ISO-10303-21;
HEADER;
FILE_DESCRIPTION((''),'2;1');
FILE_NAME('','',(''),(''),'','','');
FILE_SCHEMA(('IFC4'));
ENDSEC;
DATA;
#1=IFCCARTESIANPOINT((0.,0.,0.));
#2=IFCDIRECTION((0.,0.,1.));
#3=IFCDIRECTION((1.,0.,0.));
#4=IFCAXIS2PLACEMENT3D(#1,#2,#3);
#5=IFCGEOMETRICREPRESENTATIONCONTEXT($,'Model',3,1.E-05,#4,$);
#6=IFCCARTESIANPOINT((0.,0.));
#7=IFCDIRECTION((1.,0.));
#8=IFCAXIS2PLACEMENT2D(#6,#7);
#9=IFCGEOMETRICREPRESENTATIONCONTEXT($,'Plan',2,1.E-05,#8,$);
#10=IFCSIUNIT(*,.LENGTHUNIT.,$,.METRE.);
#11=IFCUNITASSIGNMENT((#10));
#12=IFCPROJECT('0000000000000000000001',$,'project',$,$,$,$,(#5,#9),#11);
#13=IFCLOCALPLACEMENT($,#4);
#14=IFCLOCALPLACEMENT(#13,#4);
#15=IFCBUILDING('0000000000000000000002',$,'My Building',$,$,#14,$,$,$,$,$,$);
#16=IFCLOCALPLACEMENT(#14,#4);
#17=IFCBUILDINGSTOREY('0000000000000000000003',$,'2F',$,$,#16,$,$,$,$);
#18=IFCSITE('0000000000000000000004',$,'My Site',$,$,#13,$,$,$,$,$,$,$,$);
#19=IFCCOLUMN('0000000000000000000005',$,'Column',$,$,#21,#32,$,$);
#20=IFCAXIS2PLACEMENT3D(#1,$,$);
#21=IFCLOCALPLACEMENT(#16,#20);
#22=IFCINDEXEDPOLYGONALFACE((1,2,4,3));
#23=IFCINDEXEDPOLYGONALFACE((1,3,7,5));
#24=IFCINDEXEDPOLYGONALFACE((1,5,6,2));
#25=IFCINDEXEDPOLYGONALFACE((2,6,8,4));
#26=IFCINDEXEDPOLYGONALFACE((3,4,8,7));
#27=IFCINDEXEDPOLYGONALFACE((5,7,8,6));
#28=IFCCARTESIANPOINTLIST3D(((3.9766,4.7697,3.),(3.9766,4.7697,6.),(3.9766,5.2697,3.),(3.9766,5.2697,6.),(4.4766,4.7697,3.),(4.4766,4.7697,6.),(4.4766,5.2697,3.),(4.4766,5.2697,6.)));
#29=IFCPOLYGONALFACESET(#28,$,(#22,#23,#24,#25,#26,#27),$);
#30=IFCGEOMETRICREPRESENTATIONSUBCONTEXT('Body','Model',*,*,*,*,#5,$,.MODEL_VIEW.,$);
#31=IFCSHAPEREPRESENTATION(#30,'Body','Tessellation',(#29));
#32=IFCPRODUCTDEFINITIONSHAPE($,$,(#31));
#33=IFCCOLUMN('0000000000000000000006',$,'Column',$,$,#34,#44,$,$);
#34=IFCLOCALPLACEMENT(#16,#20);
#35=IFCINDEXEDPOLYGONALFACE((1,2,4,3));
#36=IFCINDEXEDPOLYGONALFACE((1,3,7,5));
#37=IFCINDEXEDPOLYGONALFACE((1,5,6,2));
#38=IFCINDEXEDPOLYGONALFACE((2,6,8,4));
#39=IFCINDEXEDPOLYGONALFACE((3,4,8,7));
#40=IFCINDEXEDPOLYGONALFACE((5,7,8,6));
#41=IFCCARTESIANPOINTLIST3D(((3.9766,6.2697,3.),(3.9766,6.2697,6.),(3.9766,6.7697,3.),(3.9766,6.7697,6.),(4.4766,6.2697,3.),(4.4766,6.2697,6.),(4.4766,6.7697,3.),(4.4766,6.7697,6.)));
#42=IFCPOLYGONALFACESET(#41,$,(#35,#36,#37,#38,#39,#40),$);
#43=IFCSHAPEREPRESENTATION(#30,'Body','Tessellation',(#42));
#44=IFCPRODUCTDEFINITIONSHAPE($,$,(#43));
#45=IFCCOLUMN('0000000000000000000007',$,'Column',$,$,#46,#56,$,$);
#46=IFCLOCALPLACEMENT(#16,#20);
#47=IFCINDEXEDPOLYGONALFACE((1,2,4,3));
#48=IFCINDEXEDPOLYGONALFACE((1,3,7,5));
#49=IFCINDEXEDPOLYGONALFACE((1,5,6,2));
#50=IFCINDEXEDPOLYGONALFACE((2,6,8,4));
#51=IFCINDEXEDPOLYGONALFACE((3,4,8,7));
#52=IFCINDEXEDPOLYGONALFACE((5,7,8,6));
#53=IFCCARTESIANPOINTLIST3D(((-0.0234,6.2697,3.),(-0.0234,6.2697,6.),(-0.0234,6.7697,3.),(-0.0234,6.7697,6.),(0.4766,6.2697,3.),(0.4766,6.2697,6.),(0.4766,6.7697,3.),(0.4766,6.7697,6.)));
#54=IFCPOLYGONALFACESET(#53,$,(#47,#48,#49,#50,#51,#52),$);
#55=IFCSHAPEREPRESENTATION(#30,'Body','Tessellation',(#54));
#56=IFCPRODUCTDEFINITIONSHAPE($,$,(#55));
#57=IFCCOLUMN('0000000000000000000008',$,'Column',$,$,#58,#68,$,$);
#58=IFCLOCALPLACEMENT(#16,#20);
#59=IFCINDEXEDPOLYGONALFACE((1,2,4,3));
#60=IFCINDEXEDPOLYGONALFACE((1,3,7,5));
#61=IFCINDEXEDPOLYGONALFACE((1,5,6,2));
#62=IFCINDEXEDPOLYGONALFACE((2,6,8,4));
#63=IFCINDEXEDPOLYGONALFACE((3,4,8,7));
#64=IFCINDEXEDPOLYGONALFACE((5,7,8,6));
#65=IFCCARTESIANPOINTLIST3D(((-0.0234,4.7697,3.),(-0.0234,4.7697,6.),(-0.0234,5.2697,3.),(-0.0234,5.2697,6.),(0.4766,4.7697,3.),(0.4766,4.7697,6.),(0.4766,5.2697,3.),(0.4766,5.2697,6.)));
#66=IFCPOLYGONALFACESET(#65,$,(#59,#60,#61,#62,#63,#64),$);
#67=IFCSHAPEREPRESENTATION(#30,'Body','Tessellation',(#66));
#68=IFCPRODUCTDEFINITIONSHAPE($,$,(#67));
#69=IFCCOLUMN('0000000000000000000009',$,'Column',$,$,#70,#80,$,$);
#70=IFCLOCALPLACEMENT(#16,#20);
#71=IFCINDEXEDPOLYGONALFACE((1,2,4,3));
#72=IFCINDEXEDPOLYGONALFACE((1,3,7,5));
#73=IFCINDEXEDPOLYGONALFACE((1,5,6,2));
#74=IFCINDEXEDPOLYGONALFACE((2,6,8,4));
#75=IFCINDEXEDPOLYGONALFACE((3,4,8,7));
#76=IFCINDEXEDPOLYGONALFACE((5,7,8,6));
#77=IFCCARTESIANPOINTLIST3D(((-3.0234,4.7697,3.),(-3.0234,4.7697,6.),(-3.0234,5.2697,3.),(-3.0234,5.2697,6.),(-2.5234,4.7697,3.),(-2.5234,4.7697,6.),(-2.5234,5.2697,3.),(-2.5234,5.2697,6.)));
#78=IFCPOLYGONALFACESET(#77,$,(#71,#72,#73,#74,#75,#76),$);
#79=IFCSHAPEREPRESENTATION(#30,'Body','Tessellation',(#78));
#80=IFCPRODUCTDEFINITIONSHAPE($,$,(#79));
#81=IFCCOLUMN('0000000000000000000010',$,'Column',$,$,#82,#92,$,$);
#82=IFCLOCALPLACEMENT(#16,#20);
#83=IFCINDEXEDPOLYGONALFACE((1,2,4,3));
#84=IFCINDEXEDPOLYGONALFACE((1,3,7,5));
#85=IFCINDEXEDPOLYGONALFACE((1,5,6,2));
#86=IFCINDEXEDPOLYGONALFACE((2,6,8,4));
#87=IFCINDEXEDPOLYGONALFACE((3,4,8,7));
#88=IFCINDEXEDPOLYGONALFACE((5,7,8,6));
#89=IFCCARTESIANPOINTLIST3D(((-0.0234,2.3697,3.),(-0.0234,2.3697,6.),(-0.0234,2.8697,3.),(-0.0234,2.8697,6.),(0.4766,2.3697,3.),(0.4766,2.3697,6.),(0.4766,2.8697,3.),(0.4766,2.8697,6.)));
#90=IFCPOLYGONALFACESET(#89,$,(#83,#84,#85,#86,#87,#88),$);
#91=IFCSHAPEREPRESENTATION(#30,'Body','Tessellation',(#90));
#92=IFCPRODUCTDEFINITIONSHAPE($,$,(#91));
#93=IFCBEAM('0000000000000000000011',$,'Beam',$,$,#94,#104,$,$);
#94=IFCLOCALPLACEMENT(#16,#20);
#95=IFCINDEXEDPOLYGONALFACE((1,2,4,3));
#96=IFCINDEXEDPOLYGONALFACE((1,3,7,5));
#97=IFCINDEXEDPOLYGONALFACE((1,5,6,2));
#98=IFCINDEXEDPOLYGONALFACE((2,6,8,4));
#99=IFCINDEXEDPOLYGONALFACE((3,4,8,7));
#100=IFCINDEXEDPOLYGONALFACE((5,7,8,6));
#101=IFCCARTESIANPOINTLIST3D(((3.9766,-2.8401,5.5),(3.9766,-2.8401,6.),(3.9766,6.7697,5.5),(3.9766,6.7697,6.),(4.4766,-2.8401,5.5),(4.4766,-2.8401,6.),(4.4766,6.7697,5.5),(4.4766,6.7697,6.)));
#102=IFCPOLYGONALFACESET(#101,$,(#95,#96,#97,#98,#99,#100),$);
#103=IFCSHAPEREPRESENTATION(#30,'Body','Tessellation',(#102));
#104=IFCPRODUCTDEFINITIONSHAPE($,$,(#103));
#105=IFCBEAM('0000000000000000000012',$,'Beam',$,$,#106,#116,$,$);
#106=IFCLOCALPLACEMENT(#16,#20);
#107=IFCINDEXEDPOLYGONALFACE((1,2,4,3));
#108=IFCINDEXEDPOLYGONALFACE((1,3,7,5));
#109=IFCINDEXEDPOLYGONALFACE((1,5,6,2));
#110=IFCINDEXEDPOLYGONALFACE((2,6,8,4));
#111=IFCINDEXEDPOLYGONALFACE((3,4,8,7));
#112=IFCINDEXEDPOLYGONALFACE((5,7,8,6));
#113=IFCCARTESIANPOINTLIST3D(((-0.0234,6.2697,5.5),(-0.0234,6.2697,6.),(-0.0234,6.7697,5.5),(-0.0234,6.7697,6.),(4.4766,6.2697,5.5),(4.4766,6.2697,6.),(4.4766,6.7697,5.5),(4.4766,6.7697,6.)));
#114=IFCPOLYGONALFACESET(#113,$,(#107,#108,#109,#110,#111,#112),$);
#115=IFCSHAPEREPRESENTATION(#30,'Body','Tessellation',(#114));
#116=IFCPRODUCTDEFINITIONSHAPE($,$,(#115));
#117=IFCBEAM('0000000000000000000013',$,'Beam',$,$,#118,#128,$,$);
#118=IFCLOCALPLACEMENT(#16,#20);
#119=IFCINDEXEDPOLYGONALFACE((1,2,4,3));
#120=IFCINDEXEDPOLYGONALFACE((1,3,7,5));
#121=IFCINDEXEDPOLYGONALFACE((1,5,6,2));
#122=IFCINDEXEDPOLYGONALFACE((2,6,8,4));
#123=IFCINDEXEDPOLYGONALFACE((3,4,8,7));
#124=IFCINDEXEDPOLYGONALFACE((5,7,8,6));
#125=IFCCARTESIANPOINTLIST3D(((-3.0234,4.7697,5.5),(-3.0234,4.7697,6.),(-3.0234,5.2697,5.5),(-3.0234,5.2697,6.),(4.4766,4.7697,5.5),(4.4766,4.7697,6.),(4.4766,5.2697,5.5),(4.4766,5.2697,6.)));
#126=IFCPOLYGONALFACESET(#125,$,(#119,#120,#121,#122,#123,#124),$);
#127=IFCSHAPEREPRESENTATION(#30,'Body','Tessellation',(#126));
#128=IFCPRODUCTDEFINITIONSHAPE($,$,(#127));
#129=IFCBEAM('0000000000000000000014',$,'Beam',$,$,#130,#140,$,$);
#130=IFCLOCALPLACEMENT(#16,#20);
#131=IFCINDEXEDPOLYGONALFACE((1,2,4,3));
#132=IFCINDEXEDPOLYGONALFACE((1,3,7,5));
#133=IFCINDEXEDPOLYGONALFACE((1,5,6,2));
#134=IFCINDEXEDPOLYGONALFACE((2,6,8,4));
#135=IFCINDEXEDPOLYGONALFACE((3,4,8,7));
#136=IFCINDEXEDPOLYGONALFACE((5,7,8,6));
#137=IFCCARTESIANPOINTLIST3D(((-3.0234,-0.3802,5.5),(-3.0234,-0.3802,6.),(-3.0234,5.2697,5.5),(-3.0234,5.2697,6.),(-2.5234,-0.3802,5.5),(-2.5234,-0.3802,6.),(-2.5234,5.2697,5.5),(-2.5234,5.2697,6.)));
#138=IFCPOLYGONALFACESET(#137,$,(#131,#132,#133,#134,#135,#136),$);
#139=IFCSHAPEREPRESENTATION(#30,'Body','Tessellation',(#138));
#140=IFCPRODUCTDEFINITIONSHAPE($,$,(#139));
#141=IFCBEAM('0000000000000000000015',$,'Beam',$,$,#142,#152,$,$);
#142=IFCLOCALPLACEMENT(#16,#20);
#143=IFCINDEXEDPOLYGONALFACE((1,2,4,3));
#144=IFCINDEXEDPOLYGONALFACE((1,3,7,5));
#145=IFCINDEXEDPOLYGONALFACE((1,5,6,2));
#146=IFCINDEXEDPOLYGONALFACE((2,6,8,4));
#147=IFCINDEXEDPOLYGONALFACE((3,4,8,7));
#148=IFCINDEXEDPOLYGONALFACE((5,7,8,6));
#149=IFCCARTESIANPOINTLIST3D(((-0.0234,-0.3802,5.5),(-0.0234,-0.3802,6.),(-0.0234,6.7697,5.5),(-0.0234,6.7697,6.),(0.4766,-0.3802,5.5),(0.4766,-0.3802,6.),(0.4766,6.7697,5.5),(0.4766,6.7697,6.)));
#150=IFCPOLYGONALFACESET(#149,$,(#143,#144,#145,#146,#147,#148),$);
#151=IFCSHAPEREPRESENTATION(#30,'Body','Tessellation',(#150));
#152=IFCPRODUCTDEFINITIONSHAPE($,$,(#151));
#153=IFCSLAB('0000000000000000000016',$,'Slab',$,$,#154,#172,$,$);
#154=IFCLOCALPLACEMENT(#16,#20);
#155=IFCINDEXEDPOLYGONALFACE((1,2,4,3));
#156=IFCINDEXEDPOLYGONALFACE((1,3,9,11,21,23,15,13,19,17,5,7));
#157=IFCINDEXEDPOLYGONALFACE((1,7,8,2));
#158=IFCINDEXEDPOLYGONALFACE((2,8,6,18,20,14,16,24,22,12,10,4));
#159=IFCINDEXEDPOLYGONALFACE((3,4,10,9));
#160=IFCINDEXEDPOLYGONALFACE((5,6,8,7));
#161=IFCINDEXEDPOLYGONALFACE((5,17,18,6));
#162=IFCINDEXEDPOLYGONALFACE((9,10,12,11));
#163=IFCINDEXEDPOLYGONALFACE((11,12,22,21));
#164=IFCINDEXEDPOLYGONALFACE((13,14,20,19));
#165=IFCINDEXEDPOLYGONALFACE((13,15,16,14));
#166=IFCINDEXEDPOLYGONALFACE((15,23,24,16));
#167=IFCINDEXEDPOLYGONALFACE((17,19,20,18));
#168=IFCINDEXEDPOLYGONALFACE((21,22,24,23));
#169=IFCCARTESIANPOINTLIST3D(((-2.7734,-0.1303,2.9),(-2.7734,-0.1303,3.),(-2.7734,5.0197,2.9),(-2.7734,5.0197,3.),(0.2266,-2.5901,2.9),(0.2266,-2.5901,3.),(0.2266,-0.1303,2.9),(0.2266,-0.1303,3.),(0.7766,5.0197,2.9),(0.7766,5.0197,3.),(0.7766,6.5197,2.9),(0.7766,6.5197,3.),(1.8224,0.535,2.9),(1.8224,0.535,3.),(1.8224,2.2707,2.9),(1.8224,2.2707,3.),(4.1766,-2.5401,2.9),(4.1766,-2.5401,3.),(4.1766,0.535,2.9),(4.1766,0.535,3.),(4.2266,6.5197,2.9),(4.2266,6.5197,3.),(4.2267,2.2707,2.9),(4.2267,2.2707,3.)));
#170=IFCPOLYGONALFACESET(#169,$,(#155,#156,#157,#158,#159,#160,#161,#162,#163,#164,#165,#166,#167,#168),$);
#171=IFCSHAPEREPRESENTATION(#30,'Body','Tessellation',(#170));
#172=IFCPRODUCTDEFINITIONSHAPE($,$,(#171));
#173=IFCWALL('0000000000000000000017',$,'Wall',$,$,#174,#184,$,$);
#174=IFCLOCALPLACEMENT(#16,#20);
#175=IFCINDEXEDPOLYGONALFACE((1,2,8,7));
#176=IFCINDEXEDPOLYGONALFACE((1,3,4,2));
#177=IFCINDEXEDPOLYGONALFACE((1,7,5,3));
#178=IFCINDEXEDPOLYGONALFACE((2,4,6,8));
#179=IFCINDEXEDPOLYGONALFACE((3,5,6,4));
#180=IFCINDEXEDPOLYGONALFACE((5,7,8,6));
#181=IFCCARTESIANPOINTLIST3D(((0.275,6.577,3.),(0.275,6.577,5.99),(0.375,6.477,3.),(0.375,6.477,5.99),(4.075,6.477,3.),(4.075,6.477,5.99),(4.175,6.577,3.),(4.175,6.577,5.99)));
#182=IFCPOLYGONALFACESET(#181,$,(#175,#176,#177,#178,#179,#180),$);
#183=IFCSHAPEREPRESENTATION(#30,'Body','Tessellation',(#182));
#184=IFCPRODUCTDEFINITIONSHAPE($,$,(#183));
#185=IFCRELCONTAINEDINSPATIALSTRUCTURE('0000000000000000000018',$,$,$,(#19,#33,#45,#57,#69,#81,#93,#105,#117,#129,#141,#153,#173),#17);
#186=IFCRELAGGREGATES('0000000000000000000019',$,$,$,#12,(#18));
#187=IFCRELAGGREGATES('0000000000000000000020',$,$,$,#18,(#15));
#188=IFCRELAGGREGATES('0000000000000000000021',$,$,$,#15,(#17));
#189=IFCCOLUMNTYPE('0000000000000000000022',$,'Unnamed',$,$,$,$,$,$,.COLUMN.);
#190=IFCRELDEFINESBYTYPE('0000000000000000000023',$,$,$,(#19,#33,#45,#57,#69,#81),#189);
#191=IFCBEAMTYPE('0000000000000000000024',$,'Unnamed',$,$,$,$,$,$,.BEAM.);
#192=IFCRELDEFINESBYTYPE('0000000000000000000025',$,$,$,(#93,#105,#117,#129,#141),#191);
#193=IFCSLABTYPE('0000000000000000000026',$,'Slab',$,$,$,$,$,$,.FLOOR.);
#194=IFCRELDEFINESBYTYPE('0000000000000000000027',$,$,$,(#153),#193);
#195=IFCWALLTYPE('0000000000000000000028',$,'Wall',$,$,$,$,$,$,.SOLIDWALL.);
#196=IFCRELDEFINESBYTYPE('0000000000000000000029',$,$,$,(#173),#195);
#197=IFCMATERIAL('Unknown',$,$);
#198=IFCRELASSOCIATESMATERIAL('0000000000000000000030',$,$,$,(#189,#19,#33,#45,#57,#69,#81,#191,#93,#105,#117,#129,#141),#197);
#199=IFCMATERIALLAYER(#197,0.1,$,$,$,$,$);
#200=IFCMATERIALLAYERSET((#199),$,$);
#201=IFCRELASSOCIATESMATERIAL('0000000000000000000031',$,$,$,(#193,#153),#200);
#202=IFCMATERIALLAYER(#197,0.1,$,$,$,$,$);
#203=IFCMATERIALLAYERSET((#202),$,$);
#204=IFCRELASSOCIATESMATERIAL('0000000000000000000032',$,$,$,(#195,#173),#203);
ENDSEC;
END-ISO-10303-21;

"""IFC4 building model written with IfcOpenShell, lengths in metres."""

from ifc_helpers import new_model, si_unit, frame, origin_with_axes, origin_2d_with_axis, place, context, subcontext, project, spatial, line, indexed_curve, rectangle, outline, extrude, material, layer, layer_set, layer_usage, material_profile, profile_set, profile_usage, type_object, element, save


model = new_model("IFC4")

# Units and contexts
model_context = context("Model", 3, precision=1e-05, world=origin_with_axes())
plan_context = context("Plan", 2, precision=1e-05, world=origin_2d_with_axis())
body_context_1 = subcontext(model_context, "Body", "Model", "MODEL_VIEW")
ifc_project = project(units=[si_unit("LENGTHUNIT", "METRE")], contexts=[model_context, plan_context])

# Site, building, storey
site_placement = place(None, origin_with_axes())
site = spatial("IfcSite", under=ifc_project, at=site_placement, Name="My Site")
building_placement = place(site_placement, origin_with_axes())
building = spatial("IfcBuilding", under=site, at=building_placement, Name="My Building")
storey_placement = place(building_placement, origin_with_axes())
storey = spatial("IfcBuildingStorey", under=building, at=storey_placement, Name="2F")

# Columns
ifc_material = material(Name="Unknown")
ifc_material_profile_1 = material_profile(ifc_material, rectangle(XDim=0.5, YDim=0.5))
ifc_profile_set_1 = profile_set([ifc_material_profile_1])
ifc_profile_usage_1 = profile_usage(ifc_profile_set_1, cardinal=5)
column_type = type_object("IfcColumnType", Name="Unnamed", PredefinedType="COLUMN", material=ifc_profile_set_1)
column_1_placement = place(storey_placement, frame((4.2266, 5.0197, 3.0), z_axis=(0.0, 0.0, 1.0), x_axis=(1.0, 0.0, 0.0)))
element("IfcColumn", 1, at=column_1_placement, inside=storey, type_object=column_type, material=ifc_profile_usage_1, Name="Column", context=body_context_1, shape_type="SweptSolid", body=[
    extrude(rectangle(XDim=0.5, YDim=0.5), origin_with_axes(), (0.0, 0.0, 1.0), 3.0),
])
ifc_profile_usage_2 = profile_usage(ifc_profile_set_1, cardinal=5)
column_2_placement = place(storey_placement, frame((4.2266, 6.5197, 3.0), z_axis=(0.0, 0.0, 1.0), x_axis=(1.0, 0.0, 0.0)))
element("IfcColumn", 2, at=column_2_placement, inside=storey, type_object=column_type, material=ifc_profile_usage_2, Name="Column", context=body_context_1, shape_type="SweptSolid", body=[
    extrude(rectangle(XDim=0.5, YDim=0.5), origin_with_axes(), (0.0, 0.0, 1.0), 3.0),
])
ifc_profile_usage_3 = profile_usage(ifc_profile_set_1, cardinal=5)
column_3_placement = place(storey_placement, frame((0.2266, 6.5197, 3.0), z_axis=(0.0, 0.0, 1.0), x_axis=(1.0, 0.0, 0.0)))
element("IfcColumn", 3, at=column_3_placement, inside=storey, type_object=column_type, material=ifc_profile_usage_3, Name="Column", context=body_context_1, shape_type="SweptSolid", body=[
    extrude(rectangle(XDim=0.5, YDim=0.5), origin_with_axes(), (0.0, 0.0, 1.0), 3.0),
])
ifc_profile_usage_4 = profile_usage(ifc_profile_set_1, cardinal=5)
column_4_placement = place(storey_placement, frame((0.2266, 5.0197, 3.0), z_axis=(0.0, 0.0, 1.0), x_axis=(1.0, 0.0, 0.0)))
element("IfcColumn", 4, at=column_4_placement, inside=storey, type_object=column_type, material=ifc_profile_usage_4, Name="Column", context=body_context_1, shape_type="SweptSolid", body=[
    extrude(rectangle(XDim=0.5, YDim=0.5), origin_with_axes(), (0.0, 0.0, 1.0), 3.0),
])
ifc_profile_usage_5 = profile_usage(ifc_profile_set_1, cardinal=5)
column_5_placement = place(storey_placement, frame((-2.7734, 5.0197, 3.0), z_axis=(0.0, 0.0, 1.0), x_axis=(1.0, 0.0, 0.0)))
element("IfcColumn", 5, at=column_5_placement, inside=storey, type_object=column_type, material=ifc_profile_usage_5, Name="Column", context=body_context_1, shape_type="SweptSolid", body=[
    extrude(rectangle(XDim=0.5, YDim=0.5), origin_with_axes(), (0.0, 0.0, 1.0), 3.0),
])
ifc_profile_usage_6 = profile_usage(ifc_profile_set_1, cardinal=5)
column_6_placement = place(storey_placement, frame((0.2266, 2.6197, 3.0), z_axis=(0.0, 0.0, 1.0), x_axis=(1.0, 0.0, 0.0)))
element("IfcColumn", 6, at=column_6_placement, inside=storey, type_object=column_type, material=ifc_profile_usage_6, Name="Column", context=body_context_1, shape_type="SweptSolid", body=[
    extrude(rectangle(XDim=0.5, YDim=0.5), origin_with_axes(), (0.0, 0.0, 1.0), 3.0),
])

# Beams
ifc_material_profile_2 = material_profile(ifc_material, rectangle(XDim=0.5, YDim=0.5))
ifc_profile_set_2 = profile_set([ifc_material_profile_2])
ifc_profile_usage_7 = profile_usage(ifc_profile_set_2, cardinal=7)
beam_type = type_object("IfcBeamType", Name="Unnamed", PredefinedType="BEAM", material=ifc_profile_set_2)
beam_1_placement = place(storey_placement, frame((4.4766, 6.7697, 6.0), z_axis=(0.0, -1.0, 0.0), x_axis=(1.0, 0.0, 0.0)))
element("IfcBeam", 7, at=beam_1_placement, inside=storey, type_object=beam_type, material=ifc_profile_usage_7, Name="Beam", context=body_context_1, shape_type="SweptSolid", body=[
    extrude(rectangle(XDim=0.5, YDim=0.5), frame((-0.25, -0.25, 0.0), z_axis=(0.0, 0.0, 1.0), x_axis=(1.0, 0.0, 0.0)), (0.0, 0.0, 1.0), 9.6098),
])
ifc_profile_usage_8 = profile_usage(ifc_profile_set_2, cardinal=7)
beam_2_placement = place(storey_placement, frame((4.4766, 6.2697, 6.0), z_axis=(-1.0, -0.000001, 0.000001), x_axis=(0.000001, -1.0, 0.0)))
element("IfcBeam", 8, at=beam_2_placement, inside=storey, type_object=beam_type, material=ifc_profile_usage_8, Name="Beam", context=body_context_1, shape_type="SweptSolid", body=[
    extrude(rectangle(XDim=0.5, YDim=0.5), frame((-0.25, -0.25, 0.0), z_axis=(0.0, 0.0, 1.0), x_axis=(1.0, 0.0, 0.0)), (0.0, 0.0, 1.0), 4.5),
])
ifc_profile_usage_9 = profile_usage(ifc_profile_set_2, cardinal=7)
beam_3_placement = place(storey_placement, frame((4.4766, 4.7697, 6.0), z_axis=(-1.0, 0.0, 0.0), x_axis=(0.0, -1.0, 0.0)))
element("IfcBeam", 9, at=beam_3_placement, inside=storey, type_object=beam_type, material=ifc_profile_usage_9, Name="Beam", context=body_context_1, shape_type="SweptSolid", body=[
    extrude(rectangle(XDim=0.5, YDim=0.5), frame((-0.25, -0.25, 0.0), z_axis=(0.0, 0.0, 1.0), x_axis=(1.0, 0.0, 0.0)), (0.0, 0.0, 1.0), 7.5),
])
ifc_profile_usage_10 = profile_usage(ifc_profile_set_2, cardinal=7)
beam_4_placement = place(storey_placement, frame((-2.5234, 5.2697, 6.0), z_axis=(0.0, -1.0, 0.0), x_axis=(1.0, 0.0, 0.0)))
element("IfcBeam", 10, at=beam_4_placement, inside=storey, type_object=beam_type, material=ifc_profile_usage_10, Name="Beam", context=body_context_1, shape_type="SweptSolid", body=[
    extrude(rectangle(XDim=0.5, YDim=0.5), frame((-0.25, -0.25, 0.0), z_axis=(0.0, 0.0, 1.0), x_axis=(1.0, 0.0, 0.0)), (0.0, 0.0, 1.0), 5.6499),
])
ifc_profile_usage_11 = profile_usage(ifc_profile_set_2, cardinal=7)
beam_5_placement = place(storey_placement, frame((0.4766, 6.7697, 6.0), z_axis=(0.0, -1.0, 0.0), x_axis=(1.0, 0.0, 0.0)))
element("IfcBeam", 11, at=beam_5_placement, inside=storey, type_object=beam_type, material=ifc_profile_usage_11, Name="Beam", context=body_context_1, shape_type="SweptSolid", body=[
    extrude(rectangle(XDim=0.5, YDim=0.5), frame((-0.25, -0.25, 0.0), z_axis=(0.0, 0.0, 1.0), x_axis=(1.0, 0.0, 0.0)), (0.0, 0.0, 1.0), 7.15),
])

# Slab
ifc_layer_1 = layer(ifc_material, 0.1)
ifc_layer_set_1 = layer_set([ifc_layer_1])
ifc_layer_usage_1 = layer_usage(ifc_layer_set_1, "AXIS3", "POSITIVE", -0.1)
slab_type = type_object("IfcSlabType", Name="Slab", PredefinedType="FLOOR", material=ifc_layer_set_1)
slab_placement = place(storey_placement, frame((4.2266, 6.5197, 3.0), z_axis=(0.0, 0.0, 1.0), x_axis=(1.0, 0.0, 0.0)))
element("IfcSlab", 12, at=slab_placement, inside=storey, type_object=slab_type, material=ifc_layer_usage_1, Name="Slab", context=body_context_1, shape_type="SweptSolid", body=[
    extrude(outline(indexed_curve([(0.0, 0.0), (-3.45, 0.0), (-3.45, -1.5), (-7.0, -1.5), (-7.0, -6.65), (-4.0, -6.65), (-4.0, -9.1098), (-0.05, -9.0598), (-0.05, -5.9848), (-2.4042, -5.9848), (-2.4042, -4.249), (0.0001, -4.249), (0.0, 0.0)])), frame((0.0, 0.0, -0.1), z_axis=(0.0, 0.0, 1.0), x_axis=(1.0, 0.0, 0.0)), (0.0, 0.0, 1.0), 0.1),
])

# Wall
ifc_layer_2 = layer(ifc_material, 0.1)
ifc_layer_set_2 = layer_set([ifc_layer_2])
ifc_layer_usage_2 = layer_usage(ifc_layer_set_2, "AXIS2", "POSITIVE", 0.0)
wall_type = type_object("IfcWallType", Name="Wall", PredefinedType="SOLIDWALL", material=ifc_layer_set_2)
wall_1_placement = place(storey_placement, frame((4.175, 6.577, 3.0), z_axis=(0.0, 0.0, 1.0), x_axis=(-1.0, 0.0, 0.0)))
element("IfcWall", 13, at=wall_1_placement, inside=storey, type_object=wall_type, material=ifc_layer_usage_2, Name="Wall", context=body_context_1, shape_type="SweptSolid", body=[
    extrude(outline(indexed_curve([(0.0, 0.0), (0.1, 0.1), (3.8, 0.1), (3.9, 0.0)], segments=[line(1, 2, 3, 4, 1)])), origin_with_axes(), (0.0, 0.0, 1.0), 2.99),
])

save(model, "model.ifc")
